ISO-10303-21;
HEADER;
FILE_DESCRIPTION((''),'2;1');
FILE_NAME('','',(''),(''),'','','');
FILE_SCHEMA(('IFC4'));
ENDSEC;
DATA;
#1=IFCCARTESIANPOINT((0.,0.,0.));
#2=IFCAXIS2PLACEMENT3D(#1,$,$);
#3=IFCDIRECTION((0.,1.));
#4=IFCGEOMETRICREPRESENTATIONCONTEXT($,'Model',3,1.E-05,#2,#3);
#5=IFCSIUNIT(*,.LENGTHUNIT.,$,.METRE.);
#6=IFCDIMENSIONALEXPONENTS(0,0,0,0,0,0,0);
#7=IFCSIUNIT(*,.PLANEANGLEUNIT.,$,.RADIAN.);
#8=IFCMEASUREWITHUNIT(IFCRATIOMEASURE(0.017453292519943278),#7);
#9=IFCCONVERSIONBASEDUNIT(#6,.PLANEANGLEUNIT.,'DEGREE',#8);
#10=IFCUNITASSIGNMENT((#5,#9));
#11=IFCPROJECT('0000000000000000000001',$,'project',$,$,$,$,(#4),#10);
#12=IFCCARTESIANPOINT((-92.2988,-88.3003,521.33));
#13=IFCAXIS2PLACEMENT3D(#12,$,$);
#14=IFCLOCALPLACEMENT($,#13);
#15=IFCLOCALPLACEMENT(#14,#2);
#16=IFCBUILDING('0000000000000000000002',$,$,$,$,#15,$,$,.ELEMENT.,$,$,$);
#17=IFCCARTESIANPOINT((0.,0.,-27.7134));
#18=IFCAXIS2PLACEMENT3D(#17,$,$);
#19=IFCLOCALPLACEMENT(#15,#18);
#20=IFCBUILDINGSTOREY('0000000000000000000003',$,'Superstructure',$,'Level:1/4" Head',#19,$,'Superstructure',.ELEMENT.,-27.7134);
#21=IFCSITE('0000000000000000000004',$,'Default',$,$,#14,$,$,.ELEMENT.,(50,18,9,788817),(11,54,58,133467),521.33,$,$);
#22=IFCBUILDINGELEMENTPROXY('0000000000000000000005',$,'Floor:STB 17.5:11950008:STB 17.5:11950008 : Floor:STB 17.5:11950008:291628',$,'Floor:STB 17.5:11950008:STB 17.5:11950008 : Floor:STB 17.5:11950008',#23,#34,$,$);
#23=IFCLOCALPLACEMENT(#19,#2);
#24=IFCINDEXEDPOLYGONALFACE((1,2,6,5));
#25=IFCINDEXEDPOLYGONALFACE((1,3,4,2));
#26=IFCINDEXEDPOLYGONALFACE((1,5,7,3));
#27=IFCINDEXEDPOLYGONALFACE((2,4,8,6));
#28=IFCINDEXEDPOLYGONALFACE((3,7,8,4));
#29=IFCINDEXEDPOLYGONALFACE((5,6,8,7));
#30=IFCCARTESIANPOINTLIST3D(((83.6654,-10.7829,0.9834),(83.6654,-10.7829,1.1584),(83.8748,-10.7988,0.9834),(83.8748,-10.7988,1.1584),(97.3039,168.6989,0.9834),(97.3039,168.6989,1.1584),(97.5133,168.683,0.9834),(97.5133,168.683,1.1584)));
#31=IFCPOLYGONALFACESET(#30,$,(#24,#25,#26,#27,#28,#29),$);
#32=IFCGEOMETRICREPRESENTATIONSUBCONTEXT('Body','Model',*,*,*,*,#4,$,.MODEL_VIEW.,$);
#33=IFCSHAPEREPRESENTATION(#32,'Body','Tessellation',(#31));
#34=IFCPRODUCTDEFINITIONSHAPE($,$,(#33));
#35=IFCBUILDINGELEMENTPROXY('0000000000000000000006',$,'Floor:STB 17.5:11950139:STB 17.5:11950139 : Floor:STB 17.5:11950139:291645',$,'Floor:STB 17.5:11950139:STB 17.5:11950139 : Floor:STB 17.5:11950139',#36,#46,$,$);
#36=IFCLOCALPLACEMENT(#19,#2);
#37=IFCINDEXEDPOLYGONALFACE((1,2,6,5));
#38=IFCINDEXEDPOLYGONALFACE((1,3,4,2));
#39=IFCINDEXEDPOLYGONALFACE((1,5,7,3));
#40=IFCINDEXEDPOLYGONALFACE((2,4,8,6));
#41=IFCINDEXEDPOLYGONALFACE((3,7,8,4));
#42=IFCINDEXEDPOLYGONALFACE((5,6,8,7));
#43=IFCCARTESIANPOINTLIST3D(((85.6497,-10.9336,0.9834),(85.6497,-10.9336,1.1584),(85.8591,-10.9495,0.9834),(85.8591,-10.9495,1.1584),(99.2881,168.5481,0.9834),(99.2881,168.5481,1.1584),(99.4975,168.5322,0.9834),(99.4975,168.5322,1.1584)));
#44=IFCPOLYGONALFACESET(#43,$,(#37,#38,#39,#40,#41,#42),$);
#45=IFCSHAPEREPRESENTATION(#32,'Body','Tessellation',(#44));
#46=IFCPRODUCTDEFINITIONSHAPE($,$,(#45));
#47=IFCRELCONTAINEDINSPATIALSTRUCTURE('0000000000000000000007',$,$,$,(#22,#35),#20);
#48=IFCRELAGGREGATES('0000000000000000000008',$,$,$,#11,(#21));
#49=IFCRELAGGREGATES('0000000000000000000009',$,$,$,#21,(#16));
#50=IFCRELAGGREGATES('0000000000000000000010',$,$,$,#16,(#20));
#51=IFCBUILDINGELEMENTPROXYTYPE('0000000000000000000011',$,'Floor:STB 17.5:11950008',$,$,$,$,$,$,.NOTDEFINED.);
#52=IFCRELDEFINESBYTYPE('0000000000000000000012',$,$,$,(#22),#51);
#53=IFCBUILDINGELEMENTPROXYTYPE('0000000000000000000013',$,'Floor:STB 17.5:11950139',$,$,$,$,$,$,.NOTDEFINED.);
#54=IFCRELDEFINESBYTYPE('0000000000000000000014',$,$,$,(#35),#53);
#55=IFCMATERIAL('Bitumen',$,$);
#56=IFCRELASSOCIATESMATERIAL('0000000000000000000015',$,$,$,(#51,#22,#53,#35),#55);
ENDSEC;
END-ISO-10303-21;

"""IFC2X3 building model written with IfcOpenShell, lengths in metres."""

from ifc_helpers import new_model, entity, si_unit, converted_unit, direction, frame, frame_2d, origin, place, context, subcontext, project, spatial, rectangle, extrude, source, transform, mapped, material, type_object, type_shapes, element, save


model = new_model("IFC2X3")

# Units and contexts
model_context = context("Model", 3, precision=1e-05, world=origin(), true_north=direction((0.0, 1.0)))
body_context = subcontext(model_context, "Body", "Model", "MODEL_VIEW")
ifc_project = project(units=[si_unit("LENGTHUNIT", "METRE"), converted_unit("PLANEANGLEUNIT", "DEGREE", entity("IfcRatioMeasure", 0.017453292519943278), si_unit("PLANEANGLEUNIT", "RADIAN"), dimensions=[0, 0, 0, 0, 0, 0, 0])], contexts=[model_context])

# Site, building, storey
site_placement = place(None, frame((-92.2988, -88.3003, 521.33)))
site = spatial("IfcSite", under=ifc_project, at=site_placement, Name="Default", CompositionType="ELEMENT", RefLatitude=(50, 18, 9, 788817), RefLongitude=(11, 54, 58, 133467), RefElevation=521.33)
building_placement = place(site_placement, origin())
building = spatial("IfcBuilding", under=site, at=building_placement, CompositionType="ELEMENT")
storey_placement = place(building_placement, frame((0.0, 0.0, -27.7134)))
storey = spatial("IfcBuildingStorey", under=building, at=storey_placement, Name="Superstructure", ObjectType="Level:1/4\" Head", LongName="Superstructure", CompositionType="ELEMENT", Elevation=-27.7134)

# Building element proxies
ifc_material_1 = material(Name="Bitumen")
building_element_proxy_type_1 = type_object("IfcBuildingElementProxyType", Name="Floor:STB 17.5:11950008", PredefinedType="NOTDEFINED", material=ifc_material_1)
shared_shape_1 = source(origin(), body_context, "Body", "SweptSolid", [
    extrude(rectangle(XDim=179.9992, YDim=0.21, at=frame_2d((0.0, 0.0), x_axis=(1.0, 0.0))), frame((90.5893, 78.9501, -26.73), z_axis=(0.0, 0.0, 1.0), x_axis=(0.07577, 0.997125, 0.0)), (0.0, 0.0, 1.0), 0.175),
])
type_shapes(building_element_proxy_type_1, [shared_shape_1])
proxy_1_placement = place(storey_placement, frame((0.0, 0.0, 27.7134)))
element("IfcBuildingElementProxy", 1, at=proxy_1_placement, inside=storey, type_object=building_element_proxy_type_1, material=ifc_material_1, Name="Floor:STB 17.5:11950008:STB 17.5:11950008 : Floor:STB 17.5:11950008:291628", ObjectType="Floor:STB 17.5:11950008:STB 17.5:11950008 : Floor:STB 17.5:11950008", context=body_context, shape_type="MappedRepresentation", body=[
    mapped(shared_shape_1, transform((0.0, 0.0, 0.0), scale=1.0)),
])
building_element_proxy_type_2 = type_object("IfcBuildingElementProxyType", Name="Floor:STB 17.5:11950139", PredefinedType="NOTDEFINED", material=ifc_material_1)
shared_shape_2 = source(origin(), body_context, "Body", "SweptSolid", [
    extrude(rectangle(XDim=179.9992, YDim=0.21, at=frame_2d((0.0, 0.0), x_axis=(1.0, 0.0))), frame((92.5736, 78.7993, -26.73), z_axis=(0.0, 0.0, 1.0), x_axis=(0.07577, 0.997125, 0.0)), (0.0, 0.0, 1.0), 0.175),
])
type_shapes(building_element_proxy_type_2, [shared_shape_2])
proxy_2_placement = place(storey_placement, frame((0.0, 0.0, 27.7134)))
element("IfcBuildingElementProxy", 2, at=proxy_2_placement, inside=storey, type_object=building_element_proxy_type_2, material=ifc_material_1, Name="Floor:STB 17.5:11950139:STB 17.5:11950139 : Floor:STB 17.5:11950139:291645", ObjectType="Floor:STB 17.5:11950139:STB 17.5:11950139 : Floor:STB 17.5:11950139", context=body_context, shape_type="MappedRepresentation", body=[
    mapped(shared_shape_2, transform((0.0, 0.0, 0.0), scale=1.0)),
])

save(model, "model.ifc")
